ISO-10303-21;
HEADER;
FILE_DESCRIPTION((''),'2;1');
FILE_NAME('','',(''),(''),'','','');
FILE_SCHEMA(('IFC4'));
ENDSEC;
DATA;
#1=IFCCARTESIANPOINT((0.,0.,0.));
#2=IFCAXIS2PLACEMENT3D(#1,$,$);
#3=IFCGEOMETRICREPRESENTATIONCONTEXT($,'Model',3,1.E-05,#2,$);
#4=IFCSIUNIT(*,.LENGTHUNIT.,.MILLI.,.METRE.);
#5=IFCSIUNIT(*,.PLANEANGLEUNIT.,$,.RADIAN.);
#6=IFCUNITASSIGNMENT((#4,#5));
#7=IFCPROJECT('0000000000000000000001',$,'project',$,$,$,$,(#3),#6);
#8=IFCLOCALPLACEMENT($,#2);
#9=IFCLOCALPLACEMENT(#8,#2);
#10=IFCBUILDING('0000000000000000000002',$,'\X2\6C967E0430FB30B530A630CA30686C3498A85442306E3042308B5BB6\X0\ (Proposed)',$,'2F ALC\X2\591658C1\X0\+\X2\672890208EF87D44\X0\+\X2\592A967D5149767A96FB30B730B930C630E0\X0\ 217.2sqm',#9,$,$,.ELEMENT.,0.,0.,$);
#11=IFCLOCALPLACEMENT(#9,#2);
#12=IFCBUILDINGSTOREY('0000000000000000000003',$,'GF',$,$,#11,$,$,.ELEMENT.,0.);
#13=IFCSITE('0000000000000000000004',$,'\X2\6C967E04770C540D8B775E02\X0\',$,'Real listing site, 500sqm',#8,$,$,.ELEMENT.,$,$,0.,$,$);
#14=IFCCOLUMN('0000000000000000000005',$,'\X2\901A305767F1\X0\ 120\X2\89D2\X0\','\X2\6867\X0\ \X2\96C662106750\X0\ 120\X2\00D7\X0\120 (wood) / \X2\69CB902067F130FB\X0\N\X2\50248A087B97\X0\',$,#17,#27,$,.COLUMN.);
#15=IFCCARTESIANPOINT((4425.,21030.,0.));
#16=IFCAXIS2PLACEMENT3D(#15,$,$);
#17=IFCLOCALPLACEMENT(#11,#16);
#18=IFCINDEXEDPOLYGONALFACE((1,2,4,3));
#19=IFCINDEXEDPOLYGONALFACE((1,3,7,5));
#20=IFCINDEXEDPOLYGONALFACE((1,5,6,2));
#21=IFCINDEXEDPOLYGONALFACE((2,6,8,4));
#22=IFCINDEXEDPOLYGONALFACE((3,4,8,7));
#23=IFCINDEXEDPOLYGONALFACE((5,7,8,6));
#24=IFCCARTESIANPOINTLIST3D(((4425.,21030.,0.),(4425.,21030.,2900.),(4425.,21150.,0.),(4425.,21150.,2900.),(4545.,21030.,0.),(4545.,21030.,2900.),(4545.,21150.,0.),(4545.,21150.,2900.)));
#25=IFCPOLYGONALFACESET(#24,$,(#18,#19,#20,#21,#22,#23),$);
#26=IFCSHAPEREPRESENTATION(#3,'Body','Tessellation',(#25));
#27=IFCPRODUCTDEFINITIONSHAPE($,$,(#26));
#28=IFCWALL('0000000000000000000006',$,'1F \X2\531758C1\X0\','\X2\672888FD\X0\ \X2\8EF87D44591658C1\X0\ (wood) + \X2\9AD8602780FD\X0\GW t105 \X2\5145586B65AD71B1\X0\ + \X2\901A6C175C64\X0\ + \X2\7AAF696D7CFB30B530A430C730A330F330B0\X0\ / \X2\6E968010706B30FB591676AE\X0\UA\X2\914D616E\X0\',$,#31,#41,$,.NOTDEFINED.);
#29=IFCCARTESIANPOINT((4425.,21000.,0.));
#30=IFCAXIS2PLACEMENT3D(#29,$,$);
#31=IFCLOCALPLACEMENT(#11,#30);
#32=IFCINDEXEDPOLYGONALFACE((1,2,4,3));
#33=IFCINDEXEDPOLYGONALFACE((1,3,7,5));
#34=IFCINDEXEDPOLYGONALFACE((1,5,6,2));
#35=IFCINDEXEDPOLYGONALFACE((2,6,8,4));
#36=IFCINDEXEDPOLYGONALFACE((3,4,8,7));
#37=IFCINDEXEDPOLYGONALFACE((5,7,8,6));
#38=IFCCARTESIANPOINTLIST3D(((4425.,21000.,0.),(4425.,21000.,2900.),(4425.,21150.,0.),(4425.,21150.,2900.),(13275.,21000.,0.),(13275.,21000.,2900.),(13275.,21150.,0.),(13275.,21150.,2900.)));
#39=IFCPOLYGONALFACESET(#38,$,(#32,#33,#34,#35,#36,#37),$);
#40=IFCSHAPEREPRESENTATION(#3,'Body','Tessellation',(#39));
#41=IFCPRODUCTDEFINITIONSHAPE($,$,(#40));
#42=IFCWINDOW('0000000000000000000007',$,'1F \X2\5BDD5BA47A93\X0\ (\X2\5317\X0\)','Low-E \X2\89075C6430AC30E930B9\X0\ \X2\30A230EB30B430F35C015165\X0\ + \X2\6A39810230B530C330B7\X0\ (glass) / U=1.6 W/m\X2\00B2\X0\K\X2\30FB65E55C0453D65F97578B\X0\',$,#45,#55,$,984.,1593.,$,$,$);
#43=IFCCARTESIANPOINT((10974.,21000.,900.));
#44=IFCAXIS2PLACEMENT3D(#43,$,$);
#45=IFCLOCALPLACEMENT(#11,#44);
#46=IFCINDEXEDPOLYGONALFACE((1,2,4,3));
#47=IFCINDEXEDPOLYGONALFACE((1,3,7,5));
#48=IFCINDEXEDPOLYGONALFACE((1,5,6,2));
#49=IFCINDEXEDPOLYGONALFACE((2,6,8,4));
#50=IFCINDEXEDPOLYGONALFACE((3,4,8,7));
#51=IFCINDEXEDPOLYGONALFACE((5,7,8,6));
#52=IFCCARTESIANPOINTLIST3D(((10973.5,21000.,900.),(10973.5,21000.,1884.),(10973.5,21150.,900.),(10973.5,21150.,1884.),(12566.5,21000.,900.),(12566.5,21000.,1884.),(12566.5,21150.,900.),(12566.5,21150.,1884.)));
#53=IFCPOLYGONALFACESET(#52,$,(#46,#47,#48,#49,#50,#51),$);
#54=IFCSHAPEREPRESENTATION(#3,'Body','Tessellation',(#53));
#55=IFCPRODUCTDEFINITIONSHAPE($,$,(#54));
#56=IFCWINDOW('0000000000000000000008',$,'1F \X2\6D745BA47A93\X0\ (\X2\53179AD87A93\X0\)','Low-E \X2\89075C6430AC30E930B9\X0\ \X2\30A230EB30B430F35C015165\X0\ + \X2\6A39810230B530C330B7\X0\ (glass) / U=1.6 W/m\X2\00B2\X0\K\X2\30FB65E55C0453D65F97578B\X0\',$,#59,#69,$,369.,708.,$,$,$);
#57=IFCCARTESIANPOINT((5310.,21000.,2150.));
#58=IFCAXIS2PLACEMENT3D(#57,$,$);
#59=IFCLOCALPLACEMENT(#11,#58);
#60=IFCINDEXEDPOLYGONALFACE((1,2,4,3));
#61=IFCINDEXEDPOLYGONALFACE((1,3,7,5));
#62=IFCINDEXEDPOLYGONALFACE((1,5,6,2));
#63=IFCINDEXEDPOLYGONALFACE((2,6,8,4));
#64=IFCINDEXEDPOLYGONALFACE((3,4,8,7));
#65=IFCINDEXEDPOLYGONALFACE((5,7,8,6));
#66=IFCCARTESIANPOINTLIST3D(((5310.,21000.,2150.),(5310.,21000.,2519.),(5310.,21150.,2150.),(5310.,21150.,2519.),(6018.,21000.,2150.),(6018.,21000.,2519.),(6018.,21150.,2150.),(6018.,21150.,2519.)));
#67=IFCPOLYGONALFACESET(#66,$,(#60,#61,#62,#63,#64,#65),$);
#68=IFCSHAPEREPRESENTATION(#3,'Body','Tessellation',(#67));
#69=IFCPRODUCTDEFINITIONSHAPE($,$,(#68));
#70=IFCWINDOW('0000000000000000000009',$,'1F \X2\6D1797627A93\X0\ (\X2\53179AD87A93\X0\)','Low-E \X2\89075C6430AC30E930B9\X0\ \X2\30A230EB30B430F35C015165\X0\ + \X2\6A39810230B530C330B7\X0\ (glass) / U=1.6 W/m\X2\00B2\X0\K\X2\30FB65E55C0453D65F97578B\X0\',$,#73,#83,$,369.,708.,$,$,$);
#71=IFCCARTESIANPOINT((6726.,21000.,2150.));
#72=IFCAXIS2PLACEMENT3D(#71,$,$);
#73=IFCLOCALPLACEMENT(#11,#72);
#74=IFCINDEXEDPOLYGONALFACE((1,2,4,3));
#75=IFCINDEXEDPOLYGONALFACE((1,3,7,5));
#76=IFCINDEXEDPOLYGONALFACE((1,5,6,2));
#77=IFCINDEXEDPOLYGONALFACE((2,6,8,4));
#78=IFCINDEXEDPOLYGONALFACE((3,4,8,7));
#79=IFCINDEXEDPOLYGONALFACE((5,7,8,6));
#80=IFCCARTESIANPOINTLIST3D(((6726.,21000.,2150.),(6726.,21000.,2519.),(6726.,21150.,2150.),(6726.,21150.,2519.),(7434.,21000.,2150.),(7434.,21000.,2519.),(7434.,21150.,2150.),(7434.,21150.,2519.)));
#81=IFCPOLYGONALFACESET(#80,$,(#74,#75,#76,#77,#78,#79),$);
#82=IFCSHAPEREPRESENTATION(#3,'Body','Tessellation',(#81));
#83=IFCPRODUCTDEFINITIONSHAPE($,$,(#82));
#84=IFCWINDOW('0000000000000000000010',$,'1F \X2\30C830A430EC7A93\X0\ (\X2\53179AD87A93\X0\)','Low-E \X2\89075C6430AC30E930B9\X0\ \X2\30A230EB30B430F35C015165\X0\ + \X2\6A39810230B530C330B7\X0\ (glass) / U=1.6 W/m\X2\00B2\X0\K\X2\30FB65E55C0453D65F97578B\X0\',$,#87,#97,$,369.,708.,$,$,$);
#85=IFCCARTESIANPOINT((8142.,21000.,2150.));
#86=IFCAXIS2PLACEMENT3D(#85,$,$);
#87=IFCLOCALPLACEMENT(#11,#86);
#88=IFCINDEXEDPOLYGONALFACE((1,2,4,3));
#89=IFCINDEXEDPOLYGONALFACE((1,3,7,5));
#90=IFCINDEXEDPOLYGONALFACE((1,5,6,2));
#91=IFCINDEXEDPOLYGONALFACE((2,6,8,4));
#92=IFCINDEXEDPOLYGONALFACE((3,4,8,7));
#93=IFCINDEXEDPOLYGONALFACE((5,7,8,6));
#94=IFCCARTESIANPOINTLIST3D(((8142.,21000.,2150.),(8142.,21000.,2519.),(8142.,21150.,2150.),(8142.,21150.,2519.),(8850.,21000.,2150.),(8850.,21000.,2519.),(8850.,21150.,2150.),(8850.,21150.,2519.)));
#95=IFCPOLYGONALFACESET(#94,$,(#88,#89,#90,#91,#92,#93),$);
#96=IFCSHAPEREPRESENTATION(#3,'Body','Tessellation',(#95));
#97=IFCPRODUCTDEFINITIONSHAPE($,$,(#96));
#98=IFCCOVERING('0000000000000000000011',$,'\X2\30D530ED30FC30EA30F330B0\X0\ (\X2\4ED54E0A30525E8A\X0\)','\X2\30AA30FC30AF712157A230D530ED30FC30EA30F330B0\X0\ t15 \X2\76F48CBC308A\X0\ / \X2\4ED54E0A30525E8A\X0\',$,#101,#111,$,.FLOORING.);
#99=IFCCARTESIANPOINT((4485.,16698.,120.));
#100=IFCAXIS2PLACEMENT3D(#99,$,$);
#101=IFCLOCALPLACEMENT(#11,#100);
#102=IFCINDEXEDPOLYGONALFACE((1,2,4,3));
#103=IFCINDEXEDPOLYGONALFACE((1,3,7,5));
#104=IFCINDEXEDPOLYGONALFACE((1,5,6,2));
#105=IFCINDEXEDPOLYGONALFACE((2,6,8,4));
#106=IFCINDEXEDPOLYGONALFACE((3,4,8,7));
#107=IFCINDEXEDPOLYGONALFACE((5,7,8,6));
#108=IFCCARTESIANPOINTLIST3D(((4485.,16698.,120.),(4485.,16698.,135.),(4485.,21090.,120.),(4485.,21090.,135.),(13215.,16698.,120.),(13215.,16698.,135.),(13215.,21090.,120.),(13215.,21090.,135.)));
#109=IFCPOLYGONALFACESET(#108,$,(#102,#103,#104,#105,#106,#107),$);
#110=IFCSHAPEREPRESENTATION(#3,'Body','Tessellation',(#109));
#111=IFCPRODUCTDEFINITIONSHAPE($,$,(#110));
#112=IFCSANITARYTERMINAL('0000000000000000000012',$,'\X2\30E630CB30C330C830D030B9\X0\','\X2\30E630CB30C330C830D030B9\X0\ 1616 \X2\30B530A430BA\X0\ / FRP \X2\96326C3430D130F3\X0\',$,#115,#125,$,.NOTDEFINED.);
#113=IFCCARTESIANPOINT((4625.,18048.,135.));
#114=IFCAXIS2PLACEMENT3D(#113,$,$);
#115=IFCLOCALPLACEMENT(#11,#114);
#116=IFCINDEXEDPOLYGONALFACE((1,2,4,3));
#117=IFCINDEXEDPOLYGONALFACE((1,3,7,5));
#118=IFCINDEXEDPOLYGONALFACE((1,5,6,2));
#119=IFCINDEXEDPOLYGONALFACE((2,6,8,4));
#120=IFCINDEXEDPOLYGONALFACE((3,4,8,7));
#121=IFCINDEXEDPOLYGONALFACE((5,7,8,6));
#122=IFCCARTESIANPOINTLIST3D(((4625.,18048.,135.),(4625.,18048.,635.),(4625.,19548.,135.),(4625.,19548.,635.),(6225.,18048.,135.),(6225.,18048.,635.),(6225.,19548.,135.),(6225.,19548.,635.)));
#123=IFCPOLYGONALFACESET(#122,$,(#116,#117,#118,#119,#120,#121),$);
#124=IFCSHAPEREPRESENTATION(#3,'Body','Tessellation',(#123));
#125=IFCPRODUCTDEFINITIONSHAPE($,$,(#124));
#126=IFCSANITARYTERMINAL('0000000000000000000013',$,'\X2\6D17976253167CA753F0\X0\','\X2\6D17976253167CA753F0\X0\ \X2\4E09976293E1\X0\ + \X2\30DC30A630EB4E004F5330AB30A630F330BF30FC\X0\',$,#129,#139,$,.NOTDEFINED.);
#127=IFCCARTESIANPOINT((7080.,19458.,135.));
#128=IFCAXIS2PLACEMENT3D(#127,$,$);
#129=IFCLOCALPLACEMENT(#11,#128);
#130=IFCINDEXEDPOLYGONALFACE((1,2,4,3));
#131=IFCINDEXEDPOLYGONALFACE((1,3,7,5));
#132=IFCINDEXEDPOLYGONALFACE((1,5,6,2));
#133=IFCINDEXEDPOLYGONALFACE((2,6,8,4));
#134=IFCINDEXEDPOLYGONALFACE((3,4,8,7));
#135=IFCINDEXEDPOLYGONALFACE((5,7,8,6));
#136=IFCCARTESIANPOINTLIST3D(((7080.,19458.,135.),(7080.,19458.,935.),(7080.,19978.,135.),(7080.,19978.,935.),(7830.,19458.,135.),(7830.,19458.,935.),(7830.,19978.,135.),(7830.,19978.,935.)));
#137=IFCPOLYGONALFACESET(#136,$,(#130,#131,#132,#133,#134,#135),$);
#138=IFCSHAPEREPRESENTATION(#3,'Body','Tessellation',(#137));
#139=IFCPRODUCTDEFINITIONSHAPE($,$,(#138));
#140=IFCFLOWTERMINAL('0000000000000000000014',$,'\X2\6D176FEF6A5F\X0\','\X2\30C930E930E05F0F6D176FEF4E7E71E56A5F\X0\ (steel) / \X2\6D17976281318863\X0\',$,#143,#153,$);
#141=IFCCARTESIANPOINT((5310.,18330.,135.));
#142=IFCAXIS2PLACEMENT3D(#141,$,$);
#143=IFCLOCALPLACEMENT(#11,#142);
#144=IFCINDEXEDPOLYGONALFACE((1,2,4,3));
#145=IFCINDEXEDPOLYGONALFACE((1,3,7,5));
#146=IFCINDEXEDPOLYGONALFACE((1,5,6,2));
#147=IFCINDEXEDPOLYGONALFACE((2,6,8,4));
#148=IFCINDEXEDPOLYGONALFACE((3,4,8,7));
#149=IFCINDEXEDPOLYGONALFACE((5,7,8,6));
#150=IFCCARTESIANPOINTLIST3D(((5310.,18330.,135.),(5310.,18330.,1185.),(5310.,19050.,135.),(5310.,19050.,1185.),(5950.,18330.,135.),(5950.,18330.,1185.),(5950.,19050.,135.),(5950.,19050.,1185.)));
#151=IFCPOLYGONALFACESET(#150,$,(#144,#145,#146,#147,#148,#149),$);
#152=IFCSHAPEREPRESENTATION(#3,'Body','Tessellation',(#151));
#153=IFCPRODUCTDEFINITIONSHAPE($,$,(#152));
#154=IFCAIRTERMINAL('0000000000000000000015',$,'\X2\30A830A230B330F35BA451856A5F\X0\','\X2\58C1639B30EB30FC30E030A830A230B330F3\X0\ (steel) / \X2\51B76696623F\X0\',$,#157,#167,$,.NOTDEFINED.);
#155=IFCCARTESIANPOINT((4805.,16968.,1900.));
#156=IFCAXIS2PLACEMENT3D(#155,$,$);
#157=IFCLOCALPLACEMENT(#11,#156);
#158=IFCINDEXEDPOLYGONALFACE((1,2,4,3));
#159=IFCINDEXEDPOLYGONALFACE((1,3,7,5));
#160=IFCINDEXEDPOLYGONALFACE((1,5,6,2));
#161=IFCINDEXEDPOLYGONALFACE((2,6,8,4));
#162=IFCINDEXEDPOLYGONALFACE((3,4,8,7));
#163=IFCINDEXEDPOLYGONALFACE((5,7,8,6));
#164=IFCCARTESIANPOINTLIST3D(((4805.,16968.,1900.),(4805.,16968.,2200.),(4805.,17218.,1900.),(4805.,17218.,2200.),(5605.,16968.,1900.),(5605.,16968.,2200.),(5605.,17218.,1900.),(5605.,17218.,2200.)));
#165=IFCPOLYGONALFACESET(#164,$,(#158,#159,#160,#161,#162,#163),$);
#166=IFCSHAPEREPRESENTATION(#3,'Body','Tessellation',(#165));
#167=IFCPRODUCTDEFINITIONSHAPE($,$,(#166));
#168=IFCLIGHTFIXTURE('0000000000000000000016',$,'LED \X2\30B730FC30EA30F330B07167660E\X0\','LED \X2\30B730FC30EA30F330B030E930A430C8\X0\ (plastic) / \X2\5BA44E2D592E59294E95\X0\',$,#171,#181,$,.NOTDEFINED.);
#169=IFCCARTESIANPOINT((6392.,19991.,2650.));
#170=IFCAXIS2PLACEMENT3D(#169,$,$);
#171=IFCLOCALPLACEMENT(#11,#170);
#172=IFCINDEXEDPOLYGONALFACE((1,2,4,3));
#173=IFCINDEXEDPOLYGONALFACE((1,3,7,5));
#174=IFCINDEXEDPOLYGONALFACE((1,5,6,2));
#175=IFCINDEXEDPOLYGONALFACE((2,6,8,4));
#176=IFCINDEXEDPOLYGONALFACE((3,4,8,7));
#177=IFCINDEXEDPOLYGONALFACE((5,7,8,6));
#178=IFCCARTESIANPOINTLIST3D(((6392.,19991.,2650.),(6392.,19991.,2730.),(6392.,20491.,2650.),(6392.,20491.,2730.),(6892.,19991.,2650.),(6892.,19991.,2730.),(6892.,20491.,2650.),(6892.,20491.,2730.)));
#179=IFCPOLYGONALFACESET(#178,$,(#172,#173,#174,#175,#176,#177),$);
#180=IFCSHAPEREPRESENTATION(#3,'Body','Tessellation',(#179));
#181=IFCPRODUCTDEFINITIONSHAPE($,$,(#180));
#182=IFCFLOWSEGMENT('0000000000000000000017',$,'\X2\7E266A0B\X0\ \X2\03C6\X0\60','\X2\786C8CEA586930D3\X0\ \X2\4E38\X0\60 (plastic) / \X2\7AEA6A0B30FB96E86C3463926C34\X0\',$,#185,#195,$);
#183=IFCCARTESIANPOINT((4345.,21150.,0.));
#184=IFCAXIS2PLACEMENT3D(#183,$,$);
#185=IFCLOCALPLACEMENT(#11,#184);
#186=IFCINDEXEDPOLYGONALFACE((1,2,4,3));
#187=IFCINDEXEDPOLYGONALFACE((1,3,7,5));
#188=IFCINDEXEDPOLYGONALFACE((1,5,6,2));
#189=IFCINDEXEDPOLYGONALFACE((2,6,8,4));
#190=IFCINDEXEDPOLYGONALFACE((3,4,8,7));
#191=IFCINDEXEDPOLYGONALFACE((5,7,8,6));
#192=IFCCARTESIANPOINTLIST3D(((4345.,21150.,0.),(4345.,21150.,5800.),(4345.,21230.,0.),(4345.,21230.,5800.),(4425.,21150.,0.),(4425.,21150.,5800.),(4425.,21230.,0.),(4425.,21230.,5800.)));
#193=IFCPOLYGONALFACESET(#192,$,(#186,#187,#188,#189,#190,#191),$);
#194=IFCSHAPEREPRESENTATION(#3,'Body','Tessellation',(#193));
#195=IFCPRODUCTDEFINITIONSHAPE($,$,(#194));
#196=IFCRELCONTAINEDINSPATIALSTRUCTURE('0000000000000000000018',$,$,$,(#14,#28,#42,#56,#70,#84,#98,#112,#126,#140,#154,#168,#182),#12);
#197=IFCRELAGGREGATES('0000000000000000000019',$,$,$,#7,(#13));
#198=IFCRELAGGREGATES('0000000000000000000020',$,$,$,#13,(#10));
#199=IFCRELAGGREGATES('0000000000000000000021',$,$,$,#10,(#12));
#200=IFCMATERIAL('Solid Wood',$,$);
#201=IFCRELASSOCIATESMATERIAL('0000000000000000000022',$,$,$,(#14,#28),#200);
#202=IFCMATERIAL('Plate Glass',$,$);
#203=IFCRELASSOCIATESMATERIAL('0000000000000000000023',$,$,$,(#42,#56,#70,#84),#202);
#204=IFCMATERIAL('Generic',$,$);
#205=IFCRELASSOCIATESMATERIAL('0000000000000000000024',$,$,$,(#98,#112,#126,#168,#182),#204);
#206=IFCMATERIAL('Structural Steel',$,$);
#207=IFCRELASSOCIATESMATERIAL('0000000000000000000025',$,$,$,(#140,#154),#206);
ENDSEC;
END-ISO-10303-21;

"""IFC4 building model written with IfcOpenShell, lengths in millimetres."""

from ifc_helpers import new_model, si_unit, frame, frame_2d, origin, place, context, project, spatial, rectangle, extrude, material, element, fill, save


model = new_model("IFC4")

# Units and contexts
model_context = context("Model", 3, precision=1e-05, world=origin())
ifc_project = project(units=[si_unit("LENGTHUNIT", "METRE", prefix="MILLI"), si_unit("PLANEANGLEUNIT", "RADIAN")], contexts=[model_context])

# Site, building, storey
site_placement = place(None, origin())
site = spatial("IfcSite", under=ifc_project, at=site_placement, Name="沖縄県名護市", ObjectType="Real listing site, 500sqm", CompositionType="ELEMENT", RefElevation=0.0)
building_placement = place(site_placement, origin())
building = spatial("IfcBuilding", under=site, at=building_placement, Name="沖縄・サウナと水風呂のある家 (Proposed)", ObjectType="2F ALC外壁+木造軸組+太陽光発電システム 217.2sqm", CompositionType="ELEMENT", ElevationOfRefHeight=0.0, ElevationOfTerrain=0.0)
storey_placement = place(building_placement, origin())
storey = spatial("IfcBuildingStorey", under=building, at=storey_placement, Name="GF", CompositionType="ELEMENT", Elevation=0.0)

# Column
ifc_material_1 = material(Name="Solid Wood")
column_1_placement = place(storey_placement, frame((4425.0, 21030.0, 0.0)))
element("IfcColumn", 1, at=column_1_placement, inside=storey, material=ifc_material_1, Name="通し柱 120角", Description="桧 集成材 120×120 (wood) / 構造柱・N値計算", PredefinedType="COLUMN", context=model_context, shape_type="SweptSolid", body=[
    extrude(rectangle(XDim=120.0, YDim=120.0, at=frame_2d((60.0, 60.0))), frame((4425.0, 21030.0, 0.0)), (0.0, 0.0, 1.0), 2900.0),
])

# Wall, openings, windows
wall_1_placement = place(storey_placement, frame((4425.0, 21000.0, 0.0)))
wall_1 = element("IfcWall", 2, at=wall_1_placement, inside=storey, material=ifc_material_1, Name="1F 北壁", Description="木製 軸組外壁 (wood) + 高性能GW t105 充填断熱 + 通気層 + 窯業系サイディング / 準耐火・外皮UA配慮", PredefinedType="NOTDEFINED", context=model_context, shape_type="SweptSolid", body=[
    extrude(rectangle(XDim=8850.0, YDim=150.0, at=frame_2d((4425.0, 75.0))), frame((4425.0, 21000.0, 0.0)), (0.0, 0.0, 1.0), 2900.0),
])
opening_1_placement = place(storey_placement, frame((10974.0, 21000.0, 900.0)))
opening_1 = element("IfcOpeningElement", 3, at=opening_1_placement, cuts=wall_1, PredefinedType="NOTDEFINED", context=model_context, shape_type="SweptSolid", body=[
    extrude(rectangle(XDim=1593.0, YDim=150.0, at=frame_2d((796.0, 75.0))), frame((10974.0, 21000.0, 900.0)), (0.0, 0.0, 1.0), 984.0),
])
opening_2_placement = place(storey_placement, frame((5310.0, 21000.0, 2150.0)))
opening_2 = element("IfcOpeningElement", 4, at=opening_2_placement, cuts=wall_1, PredefinedType="NOTDEFINED", context=model_context, shape_type="SweptSolid", body=[
    extrude(rectangle(XDim=708.0, YDim=150.0, at=frame_2d((354.0, 75.0))), frame((5310.0, 21000.0, 2150.0)), (0.0, 0.0, 1.0), 369.0),
])
opening_3_placement = place(storey_placement, frame((6726.0, 21000.0, 2150.0)))
opening_3 = element("IfcOpeningElement", 5, at=opening_3_placement, cuts=wall_1, PredefinedType="NOTDEFINED", context=model_context, shape_type="SweptSolid", body=[
    extrude(rectangle(XDim=708.0, YDim=150.0, at=frame_2d((354.0, 75.0))), frame((6726.0, 21000.0, 2150.0)), (0.0, 0.0, 1.0), 369.0),
])
opening_4_placement = place(storey_placement, frame((8142.0, 21000.0, 2150.0)))
opening_4 = element("IfcOpeningElement", 6, at=opening_4_placement, cuts=wall_1, PredefinedType="NOTDEFINED", context=model_context, shape_type="SweptSolid", body=[
    extrude(rectangle(XDim=708.0, YDim=150.0, at=frame_2d((354.0, 75.0))), frame((8142.0, 21000.0, 2150.0)), (0.0, 0.0, 1.0), 369.0),
])
ifc_material_2 = material(Name="Plate Glass")
window_1_placement = place(storey_placement, frame((10974.0, 21000.0, 900.0)))
window_1 = element("IfcWindow", 7, at=window_1_placement, inside=storey, material=ifc_material_2, Name="1F 寝室窓 (北)", Description="Low-E 複層ガラス アルゴン封入 + 樹脂サッシ (glass) / U=1.6 W/m²K・日射取得型", OverallHeight=984.0, OverallWidth=1593.0, context=model_context, shape_type="SweptSolid", body=[
    extrude(rectangle(XDim=1593.0, YDim=150.0, at=frame_2d((796.0, 75.0))), frame((10974.0, 21000.0, 900.0)), (0.0, 0.0, 1.0), 984.0),
])
fill(opening_1, window_1)
window_2_placement = place(storey_placement, frame((5310.0, 21000.0, 2150.0)))
window_2 = element("IfcWindow", 8, at=window_2_placement, inside=storey, material=ifc_material_2, Name="1F 浴室窓 (北高窓)", Description="Low-E 複層ガラス アルゴン封入 + 樹脂サッシ (glass) / U=1.6 W/m²K・日射取得型", OverallHeight=369.0, OverallWidth=708.0, context=model_context, shape_type="SweptSolid", body=[
    extrude(rectangle(XDim=708.0, YDim=150.0, at=frame_2d((354.0, 75.0))), frame((5310.0, 21000.0, 2150.0)), (0.0, 0.0, 1.0), 369.0),
])
fill(opening_2, window_2)
window_3_placement = place(storey_placement, frame((6726.0, 21000.0, 2150.0)))
window_3 = element("IfcWindow", 9, at=window_3_placement, inside=storey, material=ifc_material_2, Name="1F 洗面窓 (北高窓)", Description="Low-E 複層ガラス アルゴン封入 + 樹脂サッシ (glass) / U=1.6 W/m²K・日射取得型", OverallHeight=369.0, OverallWidth=708.0, context=model_context, shape_type="SweptSolid", body=[
    extrude(rectangle(XDim=708.0, YDim=150.0, at=frame_2d((354.0, 75.0))), frame((6726.0, 21000.0, 2150.0)), (0.0, 0.0, 1.0), 369.0),
])
fill(opening_3, window_3)
window_4_placement = place(storey_placement, frame((8142.0, 21000.0, 2150.0)))
window_4 = element("IfcWindow", 10, at=window_4_placement, inside=storey, material=ifc_material_2, Name="1F トイレ窓 (北高窓)", Description="Low-E 複層ガラス アルゴン封入 + 樹脂サッシ (glass) / U=1.6 W/m²K・日射取得型", OverallHeight=369.0, OverallWidth=708.0, context=model_context, shape_type="SweptSolid", body=[
    extrude(rectangle(XDim=708.0, YDim=150.0, at=frame_2d((354.0, 75.0))), frame((8142.0, 21000.0, 2150.0)), (0.0, 0.0, 1.0), 369.0),
])
fill(opening_4, window_4)

# Covering
ifc_material_3 = material(Name="Generic")
covering_placement = place(storey_placement, frame((4485.0, 16698.0, 120.0)))
element("IfcCovering", 11, at=covering_placement, inside=storey, material=ifc_material_3, Name="フローリング (仕上げ床)", Description="オーク無垢フローリング t15 直貼り / 仕上げ床", PredefinedType="FLOORING", context=model_context, shape_type="SweptSolid", body=[
    extrude(rectangle(XDim=8730.0, YDim=4392.0, at=frame_2d((4365.0, 2196.0))), frame((4485.0, 16698.0, 120.0)), (0.0, 0.0, 1.0), 15.0),
])

# Sanitary terminals
sanitary_terminal_1_placement = place(storey_placement, frame((4625.0, 18048.0, 135.0)))
element("IfcSanitaryTerminal", 12, at=sanitary_terminal_1_placement, inside=storey, material=ifc_material_3, Name="ユニットバス", Description="ユニットバス 1616 サイズ / FRP 防水パン", PredefinedType="NOTDEFINED", context=model_context, shape_type="SweptSolid", body=[
    extrude(rectangle(XDim=1600.0, YDim=1500.0, at=frame_2d((800.0, 750.0))), frame((4625.0, 18048.0, 135.0)), (0.0, 0.0, 1.0), 500.0),
])
sanitary_terminal_2_placement = place(storey_placement, frame((7080.0, 19458.0, 135.0)))
element("IfcSanitaryTerminal", 13, at=sanitary_terminal_2_placement, inside=storey, material=ifc_material_3, Name="洗面化粧台", Description="洗面化粧台 三面鏡 + ボウル一体カウンター", PredefinedType="NOTDEFINED", context=model_context, shape_type="SweptSolid", body=[
    extrude(rectangle(XDim=750.0, YDim=520.0, at=frame_2d((375.0, 260.0))), frame((7080.0, 19458.0, 135.0)), (0.0, 0.0, 1.0), 800.0),
])

# Flow terminal
ifc_material_4 = material(Name="Structural Steel")
flow_terminal_placement = place(storey_placement, frame((5310.0, 18330.0, 135.0)))
element("IfcFlowTerminal", 14, at=flow_terminal_placement, inside=storey, material=ifc_material_4, Name="洗濯機", Description="ドラム式洗濯乾燥機 (steel) / 洗面脱衣", context=model_context, shape_type="SweptSolid", body=[
    extrude(rectangle(XDim=640.0, YDim=720.0, at=frame_2d((320.0, 360.0))), frame((5310.0, 18330.0, 135.0)), (0.0, 0.0, 1.0), 1050.0),
])

# Air terminal
air_terminal_placement = place(storey_placement, frame((4805.0, 16968.0, 1900.0)))
element("IfcAirTerminal", 15, at=air_terminal_placement, inside=storey, material=ifc_material_4, Name="エアコン室内機", Description="壁掛ルームエアコン (steel) / 冷暖房", PredefinedType="NOTDEFINED", context=model_context, shape_type="SweptSolid", body=[
    extrude(rectangle(XDim=800.0, YDim=250.0, at=frame_2d((400.0, 125.0))), frame((4805.0, 16968.0, 1900.0)), (0.0, 0.0, 1.0), 300.0),
])

# Light fixture
light_fixture_placement = place(storey_placement, frame((6392.0, 19991.0, 2650.0)))
element("IfcLightFixture", 16, at=light_fixture_placement, inside=storey, material=ifc_material_3, Name="LED シーリング照明", Description="LED シーリングライト (plastic) / 室中央天井", PredefinedType="NOTDEFINED", context=model_context, shape_type="SweptSolid", body=[
    extrude(rectangle(XDim=500.0, YDim=500.0, at=frame_2d((250.0, 250.0))), frame((6392.0, 19991.0, 2650.0)), (0.0, 0.0, 1.0), 80.0),
])

# Flow segment
flow_segment_placement = place(storey_placement, frame((4345.0, 21150.0, 0.0)))
element("IfcFlowSegment", 17, at=flow_segment_placement, inside=storey, material=ifc_material_3, Name="縦樋 φ60", Description="硬質塩ビ 丸60 (plastic) / 竪樋・雨水排水", context=model_context, shape_type="SweptSolid", body=[
    extrude(rectangle(XDim=80.0, YDim=80.0, at=frame_2d((40.0, 40.0))), frame((4345.0, 21150.0, 0.0)), (0.0, 0.0, 1.0), 5800.0),
])

save(model, "model.ifc")
